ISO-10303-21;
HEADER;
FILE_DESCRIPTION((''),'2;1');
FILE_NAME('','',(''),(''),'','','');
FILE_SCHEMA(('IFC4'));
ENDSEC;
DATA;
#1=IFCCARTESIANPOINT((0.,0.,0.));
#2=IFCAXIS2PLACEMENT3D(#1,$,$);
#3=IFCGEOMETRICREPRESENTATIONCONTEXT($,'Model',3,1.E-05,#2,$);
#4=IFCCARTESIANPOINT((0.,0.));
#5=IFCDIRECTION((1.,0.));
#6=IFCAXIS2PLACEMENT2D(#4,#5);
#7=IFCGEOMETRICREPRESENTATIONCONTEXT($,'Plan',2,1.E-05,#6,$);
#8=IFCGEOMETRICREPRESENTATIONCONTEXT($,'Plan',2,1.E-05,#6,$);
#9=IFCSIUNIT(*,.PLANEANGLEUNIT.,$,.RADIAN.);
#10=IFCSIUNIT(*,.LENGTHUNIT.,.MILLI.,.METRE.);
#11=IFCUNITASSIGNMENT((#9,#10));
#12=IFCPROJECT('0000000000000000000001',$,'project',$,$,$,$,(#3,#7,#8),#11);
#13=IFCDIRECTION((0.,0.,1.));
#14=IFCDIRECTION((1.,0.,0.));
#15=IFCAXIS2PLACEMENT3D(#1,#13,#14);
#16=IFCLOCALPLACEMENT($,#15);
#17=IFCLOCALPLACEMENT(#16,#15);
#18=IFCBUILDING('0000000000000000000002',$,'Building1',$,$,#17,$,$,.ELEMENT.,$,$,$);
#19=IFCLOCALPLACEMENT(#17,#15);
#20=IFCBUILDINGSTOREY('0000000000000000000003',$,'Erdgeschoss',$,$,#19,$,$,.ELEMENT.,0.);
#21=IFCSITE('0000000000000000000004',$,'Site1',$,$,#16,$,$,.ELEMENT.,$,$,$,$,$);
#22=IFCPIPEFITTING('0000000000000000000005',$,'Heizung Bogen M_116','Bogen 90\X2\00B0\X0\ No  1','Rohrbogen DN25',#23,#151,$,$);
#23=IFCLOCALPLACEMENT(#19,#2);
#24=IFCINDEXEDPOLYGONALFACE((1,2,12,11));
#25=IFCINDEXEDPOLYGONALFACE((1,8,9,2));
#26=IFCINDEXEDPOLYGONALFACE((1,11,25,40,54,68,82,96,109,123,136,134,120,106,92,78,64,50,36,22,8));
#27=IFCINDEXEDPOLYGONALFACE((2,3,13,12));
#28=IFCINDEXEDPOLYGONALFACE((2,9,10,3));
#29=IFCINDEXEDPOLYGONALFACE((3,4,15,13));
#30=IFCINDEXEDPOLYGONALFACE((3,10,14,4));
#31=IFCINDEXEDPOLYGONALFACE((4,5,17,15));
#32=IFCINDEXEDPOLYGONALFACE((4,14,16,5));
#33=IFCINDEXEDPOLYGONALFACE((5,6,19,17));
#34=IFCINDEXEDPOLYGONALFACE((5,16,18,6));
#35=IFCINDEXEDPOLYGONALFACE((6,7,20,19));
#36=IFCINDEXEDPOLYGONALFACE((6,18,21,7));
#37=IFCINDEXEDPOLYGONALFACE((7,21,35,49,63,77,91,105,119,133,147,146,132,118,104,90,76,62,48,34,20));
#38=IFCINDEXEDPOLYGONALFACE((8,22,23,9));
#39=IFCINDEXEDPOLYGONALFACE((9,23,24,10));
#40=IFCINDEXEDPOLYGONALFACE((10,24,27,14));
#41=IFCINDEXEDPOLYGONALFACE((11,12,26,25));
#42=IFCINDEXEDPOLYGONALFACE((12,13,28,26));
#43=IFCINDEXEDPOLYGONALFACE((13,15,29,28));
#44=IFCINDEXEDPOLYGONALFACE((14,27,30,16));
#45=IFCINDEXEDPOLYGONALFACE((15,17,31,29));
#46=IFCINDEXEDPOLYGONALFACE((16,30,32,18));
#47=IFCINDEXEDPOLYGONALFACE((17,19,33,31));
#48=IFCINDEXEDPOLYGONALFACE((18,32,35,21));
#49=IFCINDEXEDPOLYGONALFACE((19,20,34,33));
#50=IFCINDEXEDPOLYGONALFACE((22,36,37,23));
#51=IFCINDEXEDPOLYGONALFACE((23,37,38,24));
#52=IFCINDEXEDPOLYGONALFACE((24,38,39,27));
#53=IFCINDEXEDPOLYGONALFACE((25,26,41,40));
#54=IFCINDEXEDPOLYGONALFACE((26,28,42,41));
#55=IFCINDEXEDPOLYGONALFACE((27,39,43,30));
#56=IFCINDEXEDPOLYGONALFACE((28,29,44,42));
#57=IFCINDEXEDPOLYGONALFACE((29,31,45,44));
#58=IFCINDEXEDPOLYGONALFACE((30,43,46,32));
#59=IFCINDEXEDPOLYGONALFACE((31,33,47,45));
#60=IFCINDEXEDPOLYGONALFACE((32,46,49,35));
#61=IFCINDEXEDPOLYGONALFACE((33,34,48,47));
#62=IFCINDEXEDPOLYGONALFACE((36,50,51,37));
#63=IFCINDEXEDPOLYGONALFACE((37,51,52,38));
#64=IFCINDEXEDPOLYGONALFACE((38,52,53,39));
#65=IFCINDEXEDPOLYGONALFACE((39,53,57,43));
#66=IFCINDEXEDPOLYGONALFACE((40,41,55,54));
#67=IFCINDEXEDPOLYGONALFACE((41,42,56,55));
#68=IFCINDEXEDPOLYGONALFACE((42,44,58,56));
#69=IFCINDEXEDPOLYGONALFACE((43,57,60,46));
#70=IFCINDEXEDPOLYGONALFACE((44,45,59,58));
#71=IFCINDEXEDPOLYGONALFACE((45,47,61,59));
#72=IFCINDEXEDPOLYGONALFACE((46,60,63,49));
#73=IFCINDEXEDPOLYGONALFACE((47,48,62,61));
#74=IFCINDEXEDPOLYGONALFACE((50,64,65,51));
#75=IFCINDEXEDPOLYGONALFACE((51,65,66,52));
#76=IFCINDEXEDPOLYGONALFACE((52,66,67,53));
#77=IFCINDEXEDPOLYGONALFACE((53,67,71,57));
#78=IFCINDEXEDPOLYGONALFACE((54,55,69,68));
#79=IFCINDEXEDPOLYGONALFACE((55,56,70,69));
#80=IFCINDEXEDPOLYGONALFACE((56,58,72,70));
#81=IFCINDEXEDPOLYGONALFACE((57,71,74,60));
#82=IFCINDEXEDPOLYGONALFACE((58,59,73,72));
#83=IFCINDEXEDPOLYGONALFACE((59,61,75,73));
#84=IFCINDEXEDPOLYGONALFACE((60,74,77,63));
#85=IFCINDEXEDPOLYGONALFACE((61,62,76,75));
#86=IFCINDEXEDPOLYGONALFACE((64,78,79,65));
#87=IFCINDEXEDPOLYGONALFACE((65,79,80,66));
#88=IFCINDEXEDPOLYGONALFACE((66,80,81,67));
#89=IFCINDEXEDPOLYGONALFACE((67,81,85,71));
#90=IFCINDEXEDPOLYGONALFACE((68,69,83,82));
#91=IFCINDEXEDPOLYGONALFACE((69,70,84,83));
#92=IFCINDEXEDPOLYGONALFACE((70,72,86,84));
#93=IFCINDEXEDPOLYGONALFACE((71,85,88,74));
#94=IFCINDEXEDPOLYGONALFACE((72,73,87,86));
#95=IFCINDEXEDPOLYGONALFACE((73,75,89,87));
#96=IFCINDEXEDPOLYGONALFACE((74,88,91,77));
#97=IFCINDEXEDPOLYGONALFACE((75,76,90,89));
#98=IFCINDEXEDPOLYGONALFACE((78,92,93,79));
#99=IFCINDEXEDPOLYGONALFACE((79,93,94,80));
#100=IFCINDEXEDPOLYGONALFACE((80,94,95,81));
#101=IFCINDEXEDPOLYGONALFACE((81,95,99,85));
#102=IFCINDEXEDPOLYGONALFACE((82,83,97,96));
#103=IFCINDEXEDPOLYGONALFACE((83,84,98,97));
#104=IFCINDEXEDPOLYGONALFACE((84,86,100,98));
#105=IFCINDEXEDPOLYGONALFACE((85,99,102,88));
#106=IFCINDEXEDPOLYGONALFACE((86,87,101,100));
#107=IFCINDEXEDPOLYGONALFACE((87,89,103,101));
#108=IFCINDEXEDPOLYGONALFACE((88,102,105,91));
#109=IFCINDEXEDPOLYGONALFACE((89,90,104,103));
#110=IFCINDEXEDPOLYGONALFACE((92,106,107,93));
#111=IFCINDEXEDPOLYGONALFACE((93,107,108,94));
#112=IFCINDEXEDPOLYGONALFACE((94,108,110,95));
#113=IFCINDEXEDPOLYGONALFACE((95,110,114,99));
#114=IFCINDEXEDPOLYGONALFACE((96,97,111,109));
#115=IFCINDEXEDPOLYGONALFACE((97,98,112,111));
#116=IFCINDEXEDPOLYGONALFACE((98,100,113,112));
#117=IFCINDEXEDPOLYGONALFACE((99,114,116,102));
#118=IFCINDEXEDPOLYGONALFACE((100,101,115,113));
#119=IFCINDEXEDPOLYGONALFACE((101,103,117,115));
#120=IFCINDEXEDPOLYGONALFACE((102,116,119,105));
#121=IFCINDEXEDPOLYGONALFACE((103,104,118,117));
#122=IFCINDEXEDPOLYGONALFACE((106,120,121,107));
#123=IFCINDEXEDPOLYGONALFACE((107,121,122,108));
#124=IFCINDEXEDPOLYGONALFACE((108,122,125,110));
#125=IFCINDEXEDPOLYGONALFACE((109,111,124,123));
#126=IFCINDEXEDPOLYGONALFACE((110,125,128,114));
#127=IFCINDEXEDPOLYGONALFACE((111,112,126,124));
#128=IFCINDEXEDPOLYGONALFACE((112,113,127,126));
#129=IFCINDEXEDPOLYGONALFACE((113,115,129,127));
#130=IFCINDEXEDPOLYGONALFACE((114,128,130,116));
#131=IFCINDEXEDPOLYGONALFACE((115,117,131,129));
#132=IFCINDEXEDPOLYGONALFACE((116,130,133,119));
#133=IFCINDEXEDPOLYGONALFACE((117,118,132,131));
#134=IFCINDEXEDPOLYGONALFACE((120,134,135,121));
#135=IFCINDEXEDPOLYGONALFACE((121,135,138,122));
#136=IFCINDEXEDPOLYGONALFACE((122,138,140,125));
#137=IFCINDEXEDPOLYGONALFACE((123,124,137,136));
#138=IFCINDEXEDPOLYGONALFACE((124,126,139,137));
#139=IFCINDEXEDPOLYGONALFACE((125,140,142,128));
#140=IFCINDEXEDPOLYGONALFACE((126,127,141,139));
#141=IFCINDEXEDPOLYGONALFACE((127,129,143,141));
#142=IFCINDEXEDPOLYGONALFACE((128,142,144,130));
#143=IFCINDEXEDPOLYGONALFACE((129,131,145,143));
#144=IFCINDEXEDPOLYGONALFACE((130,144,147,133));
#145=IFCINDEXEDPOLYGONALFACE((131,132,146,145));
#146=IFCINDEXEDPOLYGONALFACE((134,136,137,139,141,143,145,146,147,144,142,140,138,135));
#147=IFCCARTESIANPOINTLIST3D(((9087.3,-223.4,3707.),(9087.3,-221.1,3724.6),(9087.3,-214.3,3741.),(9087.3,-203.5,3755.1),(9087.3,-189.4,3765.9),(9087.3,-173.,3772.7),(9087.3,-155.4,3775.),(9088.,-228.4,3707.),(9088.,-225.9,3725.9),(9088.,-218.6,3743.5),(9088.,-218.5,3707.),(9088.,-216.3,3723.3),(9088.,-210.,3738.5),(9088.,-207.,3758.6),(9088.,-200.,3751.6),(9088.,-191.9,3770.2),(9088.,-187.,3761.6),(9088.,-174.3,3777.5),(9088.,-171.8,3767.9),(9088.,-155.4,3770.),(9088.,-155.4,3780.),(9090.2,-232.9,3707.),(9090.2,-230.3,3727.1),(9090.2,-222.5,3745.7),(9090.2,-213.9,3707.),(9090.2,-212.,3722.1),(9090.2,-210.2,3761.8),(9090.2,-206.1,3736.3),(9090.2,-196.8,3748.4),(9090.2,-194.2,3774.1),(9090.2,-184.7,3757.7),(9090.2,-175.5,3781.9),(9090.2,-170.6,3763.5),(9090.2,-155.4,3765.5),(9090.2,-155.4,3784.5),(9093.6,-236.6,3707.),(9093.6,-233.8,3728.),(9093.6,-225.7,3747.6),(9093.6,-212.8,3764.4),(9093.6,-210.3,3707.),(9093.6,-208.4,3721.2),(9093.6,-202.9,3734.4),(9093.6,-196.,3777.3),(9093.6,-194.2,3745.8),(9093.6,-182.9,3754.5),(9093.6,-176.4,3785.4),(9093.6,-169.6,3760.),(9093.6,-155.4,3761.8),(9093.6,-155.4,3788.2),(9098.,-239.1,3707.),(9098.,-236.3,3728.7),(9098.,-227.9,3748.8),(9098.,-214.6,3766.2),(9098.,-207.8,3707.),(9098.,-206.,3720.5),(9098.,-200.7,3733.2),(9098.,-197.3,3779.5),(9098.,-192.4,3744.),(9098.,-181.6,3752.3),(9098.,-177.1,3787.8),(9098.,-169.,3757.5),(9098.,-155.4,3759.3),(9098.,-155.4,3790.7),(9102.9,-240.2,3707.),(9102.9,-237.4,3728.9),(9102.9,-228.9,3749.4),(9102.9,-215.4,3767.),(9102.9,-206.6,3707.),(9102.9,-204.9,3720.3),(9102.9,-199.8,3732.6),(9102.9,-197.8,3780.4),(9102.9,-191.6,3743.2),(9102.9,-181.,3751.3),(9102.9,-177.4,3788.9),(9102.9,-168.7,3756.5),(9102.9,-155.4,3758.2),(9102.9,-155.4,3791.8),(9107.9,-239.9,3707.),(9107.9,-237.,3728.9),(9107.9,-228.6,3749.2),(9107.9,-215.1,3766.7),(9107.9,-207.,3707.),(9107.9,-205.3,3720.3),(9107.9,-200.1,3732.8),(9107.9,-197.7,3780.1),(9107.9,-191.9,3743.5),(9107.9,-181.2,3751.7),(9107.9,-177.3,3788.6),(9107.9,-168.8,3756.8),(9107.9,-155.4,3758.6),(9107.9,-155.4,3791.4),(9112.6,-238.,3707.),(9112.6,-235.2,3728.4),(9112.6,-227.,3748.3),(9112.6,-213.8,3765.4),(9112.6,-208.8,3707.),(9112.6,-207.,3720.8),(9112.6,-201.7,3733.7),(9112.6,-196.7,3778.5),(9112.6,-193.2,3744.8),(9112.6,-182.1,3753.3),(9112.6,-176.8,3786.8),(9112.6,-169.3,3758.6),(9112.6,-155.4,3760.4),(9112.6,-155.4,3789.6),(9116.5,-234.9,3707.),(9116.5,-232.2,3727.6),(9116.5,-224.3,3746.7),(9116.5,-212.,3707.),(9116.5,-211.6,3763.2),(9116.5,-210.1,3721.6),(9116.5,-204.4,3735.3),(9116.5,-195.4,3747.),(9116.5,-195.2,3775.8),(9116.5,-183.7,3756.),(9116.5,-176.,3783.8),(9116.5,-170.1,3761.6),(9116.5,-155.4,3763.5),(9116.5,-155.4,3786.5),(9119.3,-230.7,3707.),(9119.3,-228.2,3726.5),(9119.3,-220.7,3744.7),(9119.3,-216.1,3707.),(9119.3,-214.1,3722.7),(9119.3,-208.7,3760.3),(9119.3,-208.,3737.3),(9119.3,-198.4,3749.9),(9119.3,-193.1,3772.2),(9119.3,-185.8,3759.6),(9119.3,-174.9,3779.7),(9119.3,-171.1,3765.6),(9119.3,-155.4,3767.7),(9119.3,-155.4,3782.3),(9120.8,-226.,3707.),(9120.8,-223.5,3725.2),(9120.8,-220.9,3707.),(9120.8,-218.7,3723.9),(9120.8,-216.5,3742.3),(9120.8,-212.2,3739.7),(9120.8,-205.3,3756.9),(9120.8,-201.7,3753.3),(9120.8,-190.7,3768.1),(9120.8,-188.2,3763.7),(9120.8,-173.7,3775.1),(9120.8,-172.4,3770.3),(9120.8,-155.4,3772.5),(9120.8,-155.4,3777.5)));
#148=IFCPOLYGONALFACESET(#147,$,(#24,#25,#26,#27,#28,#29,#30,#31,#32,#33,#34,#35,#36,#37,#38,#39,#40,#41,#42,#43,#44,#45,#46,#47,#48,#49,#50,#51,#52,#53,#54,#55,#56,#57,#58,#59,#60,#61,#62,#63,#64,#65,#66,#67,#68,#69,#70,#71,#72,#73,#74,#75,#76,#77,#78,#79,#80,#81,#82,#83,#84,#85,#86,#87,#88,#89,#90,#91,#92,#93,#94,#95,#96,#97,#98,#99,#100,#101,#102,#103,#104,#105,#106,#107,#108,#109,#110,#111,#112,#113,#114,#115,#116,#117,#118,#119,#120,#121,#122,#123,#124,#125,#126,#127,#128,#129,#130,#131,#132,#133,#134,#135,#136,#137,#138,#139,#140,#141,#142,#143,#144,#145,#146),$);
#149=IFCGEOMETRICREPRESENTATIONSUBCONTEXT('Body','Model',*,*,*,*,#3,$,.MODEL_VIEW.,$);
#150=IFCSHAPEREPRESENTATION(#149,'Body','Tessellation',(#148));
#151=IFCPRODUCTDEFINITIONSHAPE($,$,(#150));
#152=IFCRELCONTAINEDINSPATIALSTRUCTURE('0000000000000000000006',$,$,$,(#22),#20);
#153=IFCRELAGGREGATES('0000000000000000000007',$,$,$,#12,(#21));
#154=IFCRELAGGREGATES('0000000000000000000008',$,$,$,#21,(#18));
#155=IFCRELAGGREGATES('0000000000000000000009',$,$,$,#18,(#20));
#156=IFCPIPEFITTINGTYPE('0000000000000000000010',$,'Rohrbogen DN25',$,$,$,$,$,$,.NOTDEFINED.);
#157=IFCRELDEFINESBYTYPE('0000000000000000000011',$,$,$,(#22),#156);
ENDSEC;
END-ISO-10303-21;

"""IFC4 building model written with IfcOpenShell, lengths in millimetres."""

from ifc_helpers import new_model, entity, si_unit, frame, origin, origin_with_axes, origin_2d_with_axis, place, context, subcontext, project, spatial, shape, source, transform, mapped, type_object, element, save


model = new_model("IFC4")

# Units and contexts
model_context = context("Model", 3, precision=1e-05, world=origin())
plan_context_1 = context("Plan", 2, precision=1e-05, world=origin_2d_with_axis())
plan_context_2 = context("Plan", 2, precision=1e-05, world=origin_2d_with_axis())
body_context = subcontext(model_context, "Body", "Model", "MODEL_VIEW")
ifc_project = project(units=[si_unit("PLANEANGLEUNIT", "RADIAN"), si_unit("LENGTHUNIT", "METRE", prefix="MILLI")], contexts=[model_context, plan_context_1, plan_context_2])

# Site, building, storey
site_placement = place(None, origin_with_axes())
site = spatial("IfcSite", under=ifc_project, at=site_placement, Name="Site1", CompositionType="ELEMENT")
building_placement = place(site_placement, origin_with_axes())
building = spatial("IfcBuilding", under=site, at=building_placement, Name="Building1", CompositionType="ELEMENT")
storey_placement = place(building_placement, origin_with_axes())
storey = spatial("IfcBuildingStorey", under=building, at=storey_placement, Name="Erdgeschoss", CompositionType="ELEMENT", Elevation=0.0)

# Pipe fitting
pipe_fitting_type = type_object("IfcPipeFittingType", Name="Rohrbogen DN25", PredefinedType="NOTDEFINED")
shared_shape_1 = source(origin_with_axes(), body_context, "Body", "SolidModel", [
    entity("IfcRevolvedAreaSolid", entity("IfcCircleProfileDef", "AREA", None, entity("IfcAxis2Placement2D", entity("IfcCartesianPoint", [0.0, 0.0]), entity("IfcDirection", [1.0, 0.0])), 16.9), entity("IfcAxis2Placement3D", entity("IfcCartesianPoint", [-42.4, 0.0, 25.6]), entity("IfcDirection", [1.0, 0.0, 0.0]), entity("IfcDirection", [0.0, -1.0, 0.0])), entity("IfcAxis1Placement", entity("IfcCartesianPoint", [0.0, 68.0, 0.0]), entity("IfcDirection", [-1.0, 0.0, 0.0])), 1.570796),
])
pipe_fitting_1_placement = place(storey_placement, frame((9104.1, -197.9, 3749.4), z_axis=(0.0, 0.0, 1.0), x_axis=(1.0, 0.0, 0.0)))
element("IfcPipeFitting", 1, at=pipe_fitting_1_placement, inside=storey, type_object=pipe_fitting_type, Name="Heizung Bogen M_116", Description="Bogen 90° No  1", ObjectType="Rohrbogen DN25", shapes=[
    shape(body_context, "Body", "MappedRepresentation", [mapped(shared_shape_1, transform((0.0, 0.0, 0.0), x_axis=(0.0, -1.0, 0.0), y_axis=(1.0, 0.0, 0.0), z_axis=(0.0, 0.0, 1.0), scale=1.0))]),
    shape(body_context, "Body", "MappedRepresentation", [mapped(shared_shape_1, transform((0.0, 0.0, 0.0), x_axis=(0.0, -1.0, 0.0), y_axis=(1.0, 0.0, 0.0), z_axis=(0.0, 0.0, 1.0), scale=1.0))]),
])

save(model, "model.ifc")
